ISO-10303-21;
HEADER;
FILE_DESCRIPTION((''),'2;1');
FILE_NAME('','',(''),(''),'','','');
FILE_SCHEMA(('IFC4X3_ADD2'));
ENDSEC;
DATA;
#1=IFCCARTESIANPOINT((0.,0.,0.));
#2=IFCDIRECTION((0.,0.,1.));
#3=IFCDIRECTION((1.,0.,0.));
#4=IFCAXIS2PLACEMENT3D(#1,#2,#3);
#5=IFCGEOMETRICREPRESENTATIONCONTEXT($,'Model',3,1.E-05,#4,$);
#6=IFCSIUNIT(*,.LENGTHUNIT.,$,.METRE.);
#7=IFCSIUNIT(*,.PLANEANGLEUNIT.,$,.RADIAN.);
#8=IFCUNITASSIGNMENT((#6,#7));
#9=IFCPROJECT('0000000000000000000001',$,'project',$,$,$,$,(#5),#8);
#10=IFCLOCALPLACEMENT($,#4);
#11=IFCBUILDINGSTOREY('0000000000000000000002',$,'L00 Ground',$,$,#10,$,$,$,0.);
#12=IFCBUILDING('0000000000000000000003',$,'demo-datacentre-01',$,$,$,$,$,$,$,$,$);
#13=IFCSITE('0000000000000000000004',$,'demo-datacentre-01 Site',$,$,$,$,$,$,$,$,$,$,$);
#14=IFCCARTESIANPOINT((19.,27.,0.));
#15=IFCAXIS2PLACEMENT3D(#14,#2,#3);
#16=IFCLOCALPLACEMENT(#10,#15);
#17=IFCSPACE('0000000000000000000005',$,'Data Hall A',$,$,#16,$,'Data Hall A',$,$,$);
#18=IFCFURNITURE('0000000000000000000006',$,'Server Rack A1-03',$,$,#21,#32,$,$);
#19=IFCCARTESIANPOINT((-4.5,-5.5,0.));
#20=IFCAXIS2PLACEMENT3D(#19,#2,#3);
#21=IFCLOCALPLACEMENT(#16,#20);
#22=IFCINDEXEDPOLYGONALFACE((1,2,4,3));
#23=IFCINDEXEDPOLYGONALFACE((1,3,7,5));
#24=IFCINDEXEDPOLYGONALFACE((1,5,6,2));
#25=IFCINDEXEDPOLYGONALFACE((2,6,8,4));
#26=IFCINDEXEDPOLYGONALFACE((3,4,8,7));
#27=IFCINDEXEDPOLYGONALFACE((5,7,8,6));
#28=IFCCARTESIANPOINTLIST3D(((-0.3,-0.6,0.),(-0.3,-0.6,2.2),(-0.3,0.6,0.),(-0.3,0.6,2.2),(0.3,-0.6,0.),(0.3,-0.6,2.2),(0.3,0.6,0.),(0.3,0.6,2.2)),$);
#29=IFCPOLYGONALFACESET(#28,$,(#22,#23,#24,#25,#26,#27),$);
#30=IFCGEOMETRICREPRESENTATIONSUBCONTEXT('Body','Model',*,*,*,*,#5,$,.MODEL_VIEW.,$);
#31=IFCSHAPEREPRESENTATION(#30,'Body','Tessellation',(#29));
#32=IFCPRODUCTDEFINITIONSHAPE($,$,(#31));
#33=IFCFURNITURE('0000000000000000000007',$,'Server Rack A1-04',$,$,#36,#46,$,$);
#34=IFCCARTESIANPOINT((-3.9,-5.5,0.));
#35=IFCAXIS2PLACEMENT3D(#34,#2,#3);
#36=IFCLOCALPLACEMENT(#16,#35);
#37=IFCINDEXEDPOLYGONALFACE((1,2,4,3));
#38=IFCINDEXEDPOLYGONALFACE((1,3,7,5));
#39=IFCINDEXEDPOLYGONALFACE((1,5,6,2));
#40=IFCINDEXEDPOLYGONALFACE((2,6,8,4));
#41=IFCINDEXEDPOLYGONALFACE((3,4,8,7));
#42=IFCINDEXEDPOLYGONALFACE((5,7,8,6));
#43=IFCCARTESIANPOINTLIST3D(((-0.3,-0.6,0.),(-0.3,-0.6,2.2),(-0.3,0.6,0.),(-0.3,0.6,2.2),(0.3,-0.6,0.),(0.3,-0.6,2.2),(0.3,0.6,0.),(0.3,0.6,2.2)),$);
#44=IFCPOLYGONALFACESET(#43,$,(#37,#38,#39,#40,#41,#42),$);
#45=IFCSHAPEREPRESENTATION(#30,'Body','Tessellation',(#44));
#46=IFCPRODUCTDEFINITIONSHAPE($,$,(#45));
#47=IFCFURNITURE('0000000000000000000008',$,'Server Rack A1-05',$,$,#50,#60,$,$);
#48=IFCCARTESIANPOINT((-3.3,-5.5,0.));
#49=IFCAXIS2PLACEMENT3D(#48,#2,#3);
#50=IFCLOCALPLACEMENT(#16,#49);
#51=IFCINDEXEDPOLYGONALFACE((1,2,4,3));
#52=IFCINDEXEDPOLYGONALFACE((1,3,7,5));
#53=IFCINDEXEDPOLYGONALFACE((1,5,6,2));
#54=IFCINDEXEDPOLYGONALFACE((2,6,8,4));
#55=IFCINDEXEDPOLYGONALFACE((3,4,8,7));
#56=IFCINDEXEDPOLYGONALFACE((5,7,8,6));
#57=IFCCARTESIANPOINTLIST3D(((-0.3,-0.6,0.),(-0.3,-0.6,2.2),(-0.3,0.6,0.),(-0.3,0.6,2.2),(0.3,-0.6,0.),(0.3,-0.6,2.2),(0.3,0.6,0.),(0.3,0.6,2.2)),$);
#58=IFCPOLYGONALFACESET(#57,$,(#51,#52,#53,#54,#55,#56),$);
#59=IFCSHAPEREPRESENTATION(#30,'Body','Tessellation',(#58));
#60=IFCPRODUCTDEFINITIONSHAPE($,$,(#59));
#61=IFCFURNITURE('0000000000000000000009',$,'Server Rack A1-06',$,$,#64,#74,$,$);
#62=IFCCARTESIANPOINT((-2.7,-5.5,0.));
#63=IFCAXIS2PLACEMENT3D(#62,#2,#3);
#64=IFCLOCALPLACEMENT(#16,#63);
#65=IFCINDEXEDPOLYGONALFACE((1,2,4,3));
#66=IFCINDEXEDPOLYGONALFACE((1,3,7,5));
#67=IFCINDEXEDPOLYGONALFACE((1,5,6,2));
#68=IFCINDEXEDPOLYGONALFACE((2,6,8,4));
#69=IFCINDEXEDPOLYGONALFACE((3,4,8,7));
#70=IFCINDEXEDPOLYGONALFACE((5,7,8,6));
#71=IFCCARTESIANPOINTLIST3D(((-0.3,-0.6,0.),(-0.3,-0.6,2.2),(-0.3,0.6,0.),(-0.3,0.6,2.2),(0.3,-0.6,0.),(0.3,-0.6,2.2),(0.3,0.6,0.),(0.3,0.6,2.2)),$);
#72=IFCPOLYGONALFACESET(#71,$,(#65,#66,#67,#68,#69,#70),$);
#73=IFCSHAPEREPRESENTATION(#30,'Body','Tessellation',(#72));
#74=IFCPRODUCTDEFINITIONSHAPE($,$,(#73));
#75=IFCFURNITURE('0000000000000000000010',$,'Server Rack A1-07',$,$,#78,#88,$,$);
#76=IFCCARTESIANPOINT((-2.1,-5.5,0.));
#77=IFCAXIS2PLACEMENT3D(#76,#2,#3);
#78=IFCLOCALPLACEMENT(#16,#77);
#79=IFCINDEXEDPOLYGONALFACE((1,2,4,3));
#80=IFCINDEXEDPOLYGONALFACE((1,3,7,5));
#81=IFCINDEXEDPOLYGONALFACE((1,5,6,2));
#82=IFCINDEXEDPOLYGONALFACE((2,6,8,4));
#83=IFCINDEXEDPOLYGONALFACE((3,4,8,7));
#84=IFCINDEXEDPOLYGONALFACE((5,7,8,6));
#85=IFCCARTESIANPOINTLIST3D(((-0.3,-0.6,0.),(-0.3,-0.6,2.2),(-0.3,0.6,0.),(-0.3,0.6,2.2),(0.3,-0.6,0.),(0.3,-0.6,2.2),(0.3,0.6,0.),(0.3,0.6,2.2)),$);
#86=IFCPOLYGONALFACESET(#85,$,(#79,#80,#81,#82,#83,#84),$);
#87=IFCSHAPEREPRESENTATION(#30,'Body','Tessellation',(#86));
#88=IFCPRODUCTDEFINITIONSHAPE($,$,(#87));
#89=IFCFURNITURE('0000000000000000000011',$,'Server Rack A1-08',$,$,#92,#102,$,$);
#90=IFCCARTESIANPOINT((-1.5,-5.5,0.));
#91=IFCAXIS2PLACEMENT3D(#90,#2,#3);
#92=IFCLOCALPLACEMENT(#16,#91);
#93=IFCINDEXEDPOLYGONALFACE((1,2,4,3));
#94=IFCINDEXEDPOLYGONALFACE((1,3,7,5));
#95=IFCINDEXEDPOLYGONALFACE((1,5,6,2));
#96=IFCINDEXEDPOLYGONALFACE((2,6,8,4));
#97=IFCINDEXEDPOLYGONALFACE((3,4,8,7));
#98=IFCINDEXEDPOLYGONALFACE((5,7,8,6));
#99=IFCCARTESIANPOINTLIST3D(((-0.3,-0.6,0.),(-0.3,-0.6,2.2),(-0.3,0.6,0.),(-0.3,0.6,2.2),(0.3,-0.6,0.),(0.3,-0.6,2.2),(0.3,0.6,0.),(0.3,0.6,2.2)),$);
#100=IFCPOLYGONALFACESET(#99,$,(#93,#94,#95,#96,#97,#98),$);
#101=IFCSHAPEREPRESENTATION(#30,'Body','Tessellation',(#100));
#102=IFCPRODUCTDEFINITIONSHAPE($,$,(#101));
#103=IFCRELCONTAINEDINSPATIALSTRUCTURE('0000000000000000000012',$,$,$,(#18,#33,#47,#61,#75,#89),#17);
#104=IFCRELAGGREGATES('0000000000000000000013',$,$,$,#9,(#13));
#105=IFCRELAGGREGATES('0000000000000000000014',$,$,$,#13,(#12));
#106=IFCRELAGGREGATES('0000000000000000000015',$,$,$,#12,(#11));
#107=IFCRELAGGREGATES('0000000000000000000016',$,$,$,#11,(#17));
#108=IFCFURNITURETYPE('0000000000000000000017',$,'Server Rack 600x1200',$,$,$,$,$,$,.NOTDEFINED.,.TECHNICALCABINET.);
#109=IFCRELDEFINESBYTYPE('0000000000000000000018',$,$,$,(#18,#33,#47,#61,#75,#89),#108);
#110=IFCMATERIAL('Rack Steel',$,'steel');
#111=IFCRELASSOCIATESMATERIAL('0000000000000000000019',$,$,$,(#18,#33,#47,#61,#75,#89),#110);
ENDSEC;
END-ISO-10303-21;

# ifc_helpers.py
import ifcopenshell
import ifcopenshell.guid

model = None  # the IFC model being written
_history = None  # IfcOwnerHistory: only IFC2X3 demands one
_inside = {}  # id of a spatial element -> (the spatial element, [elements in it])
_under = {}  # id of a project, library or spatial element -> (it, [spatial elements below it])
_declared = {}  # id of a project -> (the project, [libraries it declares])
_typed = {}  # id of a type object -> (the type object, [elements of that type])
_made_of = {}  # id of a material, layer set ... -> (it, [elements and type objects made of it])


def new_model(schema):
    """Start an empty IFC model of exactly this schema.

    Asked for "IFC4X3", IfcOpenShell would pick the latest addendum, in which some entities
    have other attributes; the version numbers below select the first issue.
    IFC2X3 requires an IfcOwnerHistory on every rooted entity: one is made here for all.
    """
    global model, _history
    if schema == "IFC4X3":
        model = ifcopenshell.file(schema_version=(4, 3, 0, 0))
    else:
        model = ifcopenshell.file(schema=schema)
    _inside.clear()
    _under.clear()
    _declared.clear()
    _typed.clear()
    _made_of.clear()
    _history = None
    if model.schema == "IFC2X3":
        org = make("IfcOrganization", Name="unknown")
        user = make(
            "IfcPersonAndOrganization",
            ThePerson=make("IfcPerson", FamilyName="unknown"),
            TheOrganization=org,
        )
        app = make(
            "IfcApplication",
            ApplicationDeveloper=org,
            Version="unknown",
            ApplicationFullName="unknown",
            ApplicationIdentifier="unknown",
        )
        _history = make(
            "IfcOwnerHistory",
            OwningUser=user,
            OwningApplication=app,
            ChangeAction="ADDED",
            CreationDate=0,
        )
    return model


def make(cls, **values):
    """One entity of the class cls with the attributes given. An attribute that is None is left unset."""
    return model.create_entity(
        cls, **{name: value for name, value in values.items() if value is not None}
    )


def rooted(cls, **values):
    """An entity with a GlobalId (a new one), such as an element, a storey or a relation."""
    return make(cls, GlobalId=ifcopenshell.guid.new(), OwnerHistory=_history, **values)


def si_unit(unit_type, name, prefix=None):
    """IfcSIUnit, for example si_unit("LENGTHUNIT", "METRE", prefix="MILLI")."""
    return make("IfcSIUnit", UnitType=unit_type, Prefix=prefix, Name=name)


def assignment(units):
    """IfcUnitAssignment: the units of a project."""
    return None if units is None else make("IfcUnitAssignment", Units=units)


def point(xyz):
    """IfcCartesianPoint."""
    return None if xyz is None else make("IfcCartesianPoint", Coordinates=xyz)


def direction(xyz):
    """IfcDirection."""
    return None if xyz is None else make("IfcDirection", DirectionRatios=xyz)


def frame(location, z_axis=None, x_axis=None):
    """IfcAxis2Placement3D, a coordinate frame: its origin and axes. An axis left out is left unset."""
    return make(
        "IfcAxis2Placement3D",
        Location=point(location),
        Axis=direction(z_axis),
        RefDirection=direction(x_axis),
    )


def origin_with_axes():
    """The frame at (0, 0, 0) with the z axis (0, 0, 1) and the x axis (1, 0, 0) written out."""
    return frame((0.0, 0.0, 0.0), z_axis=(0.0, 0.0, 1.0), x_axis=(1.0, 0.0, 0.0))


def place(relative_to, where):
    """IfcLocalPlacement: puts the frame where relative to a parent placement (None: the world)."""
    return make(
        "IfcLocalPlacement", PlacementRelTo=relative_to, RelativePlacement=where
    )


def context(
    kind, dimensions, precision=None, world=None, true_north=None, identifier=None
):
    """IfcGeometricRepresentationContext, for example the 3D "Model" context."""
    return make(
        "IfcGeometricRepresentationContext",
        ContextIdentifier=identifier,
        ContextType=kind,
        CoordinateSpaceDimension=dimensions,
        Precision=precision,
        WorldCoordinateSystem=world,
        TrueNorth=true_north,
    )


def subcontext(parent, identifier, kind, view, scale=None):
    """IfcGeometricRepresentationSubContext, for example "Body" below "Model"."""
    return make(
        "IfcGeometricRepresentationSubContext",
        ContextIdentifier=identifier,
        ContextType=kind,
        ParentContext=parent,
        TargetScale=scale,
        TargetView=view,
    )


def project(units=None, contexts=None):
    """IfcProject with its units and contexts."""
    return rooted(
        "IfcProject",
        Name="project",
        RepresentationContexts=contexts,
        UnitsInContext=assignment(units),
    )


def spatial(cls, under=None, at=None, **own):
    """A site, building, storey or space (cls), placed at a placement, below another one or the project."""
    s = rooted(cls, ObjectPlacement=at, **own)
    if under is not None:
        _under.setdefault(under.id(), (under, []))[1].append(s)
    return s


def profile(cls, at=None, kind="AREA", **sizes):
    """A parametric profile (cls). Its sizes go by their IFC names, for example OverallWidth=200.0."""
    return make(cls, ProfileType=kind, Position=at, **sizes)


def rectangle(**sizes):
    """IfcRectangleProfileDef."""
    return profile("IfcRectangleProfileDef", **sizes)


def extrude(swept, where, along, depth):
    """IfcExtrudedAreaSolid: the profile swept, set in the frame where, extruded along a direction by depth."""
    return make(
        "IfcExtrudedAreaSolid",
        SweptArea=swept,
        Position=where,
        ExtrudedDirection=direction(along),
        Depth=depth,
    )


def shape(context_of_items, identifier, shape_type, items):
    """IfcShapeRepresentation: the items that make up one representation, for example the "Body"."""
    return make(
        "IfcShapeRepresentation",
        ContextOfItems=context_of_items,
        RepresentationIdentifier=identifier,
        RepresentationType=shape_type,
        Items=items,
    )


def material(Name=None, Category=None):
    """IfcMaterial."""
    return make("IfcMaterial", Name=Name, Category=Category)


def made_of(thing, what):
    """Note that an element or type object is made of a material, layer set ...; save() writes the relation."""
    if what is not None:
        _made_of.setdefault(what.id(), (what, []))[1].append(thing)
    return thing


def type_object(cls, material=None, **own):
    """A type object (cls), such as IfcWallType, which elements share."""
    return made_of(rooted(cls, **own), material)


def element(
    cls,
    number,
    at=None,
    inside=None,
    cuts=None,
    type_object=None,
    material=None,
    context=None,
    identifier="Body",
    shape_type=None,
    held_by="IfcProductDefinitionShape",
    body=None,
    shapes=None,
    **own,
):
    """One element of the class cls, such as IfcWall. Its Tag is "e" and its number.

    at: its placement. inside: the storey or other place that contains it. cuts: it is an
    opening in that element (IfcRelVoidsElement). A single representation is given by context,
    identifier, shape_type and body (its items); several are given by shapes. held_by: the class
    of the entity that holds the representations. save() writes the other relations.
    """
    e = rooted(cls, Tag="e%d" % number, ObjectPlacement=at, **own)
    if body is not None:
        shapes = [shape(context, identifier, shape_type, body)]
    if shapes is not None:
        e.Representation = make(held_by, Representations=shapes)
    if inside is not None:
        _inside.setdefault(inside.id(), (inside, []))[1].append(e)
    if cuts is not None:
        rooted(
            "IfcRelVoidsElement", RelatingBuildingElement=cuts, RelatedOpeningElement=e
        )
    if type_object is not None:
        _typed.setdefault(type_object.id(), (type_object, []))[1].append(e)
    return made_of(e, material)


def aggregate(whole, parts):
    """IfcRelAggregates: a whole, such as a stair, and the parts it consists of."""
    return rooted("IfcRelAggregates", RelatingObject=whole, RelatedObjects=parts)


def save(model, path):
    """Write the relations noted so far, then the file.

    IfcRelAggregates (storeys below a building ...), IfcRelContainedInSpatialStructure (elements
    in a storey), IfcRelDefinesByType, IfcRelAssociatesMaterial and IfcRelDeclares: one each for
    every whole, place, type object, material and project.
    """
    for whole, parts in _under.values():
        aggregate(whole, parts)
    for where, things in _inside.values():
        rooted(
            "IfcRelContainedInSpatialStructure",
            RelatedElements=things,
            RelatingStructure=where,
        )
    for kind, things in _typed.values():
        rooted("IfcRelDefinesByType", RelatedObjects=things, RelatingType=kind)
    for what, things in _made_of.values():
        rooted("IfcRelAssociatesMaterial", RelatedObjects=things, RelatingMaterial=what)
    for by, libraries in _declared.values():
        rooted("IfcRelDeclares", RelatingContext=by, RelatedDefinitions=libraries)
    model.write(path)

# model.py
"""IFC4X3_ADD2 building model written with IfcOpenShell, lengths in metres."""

from ifc_helpers import new_model, si_unit, frame, origin_with_axes, place, context, subcontext, project, spatial, rectangle, extrude, material, type_object, element, save


model = new_model("IFC4X3_ADD2")

# Units and contexts
model_context = context("Model", 3, precision=1e-05, world=origin_with_axes())
body_context = subcontext(model_context, "Body", "Model", "MODEL_VIEW")
ifc_project = project(units=[si_unit("LENGTHUNIT", "METRE"), si_unit("PLANEANGLEUNIT", "RADIAN")], contexts=[model_context])

# Site, building, storey
site = spatial("IfcSite", under=ifc_project, Name="demo-datacentre-01 Site")
building = spatial("IfcBuilding", under=site, Name="demo-datacentre-01")
storey_placement = place(None, origin_with_axes())
storey = spatial("IfcBuildingStorey", under=building, at=storey_placement, Name="L00 Ground", Elevation=0.0)

# Shared definitions
space_placement = place(storey_placement, frame((19.0, 27.0, 0.0), z_axis=(0.0, 0.0, 1.0), x_axis=(1.0, 0.0, 0.0)))
space = spatial("IfcSpace", under=storey, at=space_placement, Name="Data Hall A", LongName="Data Hall A")

# Furniture
ifc_material_1 = material(Name="Rack Steel", Category="steel")
furniture_type = type_object("IfcFurnitureType", Name="Server Rack 600x1200", AssemblyPlace="NOTDEFINED", PredefinedType="TECHNICALCABINET")
for number, where, z_axis, x_axis, name in (
    (1, (-4.5, -5.5, 0.0), (0.0, 0.0, 1.0), (1.0, 0.0, 0.0), "Server Rack A1-03"),
    (2, (-3.9, -5.5, 0.0), (0.0, 0.0, 1.0), (1.0, 0.0, 0.0), "Server Rack A1-04"),
    (3, (-3.3, -5.5, 0.0), (0.0, 0.0, 1.0), (1.0, 0.0, 0.0), "Server Rack A1-05"),
    (4, (-2.7, -5.5, 0.0), (0.0, 0.0, 1.0), (1.0, 0.0, 0.0), "Server Rack A1-06"),
    (5, (-2.1, -5.5, 0.0), (0.0, 0.0, 1.0), (1.0, 0.0, 0.0), "Server Rack A1-07"),
    (6, (-1.5, -5.5, 0.0), (0.0, 0.0, 1.0), (1.0, 0.0, 0.0), "Server Rack A1-08"),
):
    element("IfcFurniture", number, at=place(space_placement, frame(where, z_axis=z_axis, x_axis=x_axis)), inside=space, type_object=furniture_type, material=ifc_material_1, Name=name, context=body_context, shape_type="SweptSolid", body=[
        extrude(rectangle(XDim=0.6, YDim=1.2), origin_with_axes(), (0.0, 0.0, 1.0), 2.2),
    ])

save(model, "model.ifc")
